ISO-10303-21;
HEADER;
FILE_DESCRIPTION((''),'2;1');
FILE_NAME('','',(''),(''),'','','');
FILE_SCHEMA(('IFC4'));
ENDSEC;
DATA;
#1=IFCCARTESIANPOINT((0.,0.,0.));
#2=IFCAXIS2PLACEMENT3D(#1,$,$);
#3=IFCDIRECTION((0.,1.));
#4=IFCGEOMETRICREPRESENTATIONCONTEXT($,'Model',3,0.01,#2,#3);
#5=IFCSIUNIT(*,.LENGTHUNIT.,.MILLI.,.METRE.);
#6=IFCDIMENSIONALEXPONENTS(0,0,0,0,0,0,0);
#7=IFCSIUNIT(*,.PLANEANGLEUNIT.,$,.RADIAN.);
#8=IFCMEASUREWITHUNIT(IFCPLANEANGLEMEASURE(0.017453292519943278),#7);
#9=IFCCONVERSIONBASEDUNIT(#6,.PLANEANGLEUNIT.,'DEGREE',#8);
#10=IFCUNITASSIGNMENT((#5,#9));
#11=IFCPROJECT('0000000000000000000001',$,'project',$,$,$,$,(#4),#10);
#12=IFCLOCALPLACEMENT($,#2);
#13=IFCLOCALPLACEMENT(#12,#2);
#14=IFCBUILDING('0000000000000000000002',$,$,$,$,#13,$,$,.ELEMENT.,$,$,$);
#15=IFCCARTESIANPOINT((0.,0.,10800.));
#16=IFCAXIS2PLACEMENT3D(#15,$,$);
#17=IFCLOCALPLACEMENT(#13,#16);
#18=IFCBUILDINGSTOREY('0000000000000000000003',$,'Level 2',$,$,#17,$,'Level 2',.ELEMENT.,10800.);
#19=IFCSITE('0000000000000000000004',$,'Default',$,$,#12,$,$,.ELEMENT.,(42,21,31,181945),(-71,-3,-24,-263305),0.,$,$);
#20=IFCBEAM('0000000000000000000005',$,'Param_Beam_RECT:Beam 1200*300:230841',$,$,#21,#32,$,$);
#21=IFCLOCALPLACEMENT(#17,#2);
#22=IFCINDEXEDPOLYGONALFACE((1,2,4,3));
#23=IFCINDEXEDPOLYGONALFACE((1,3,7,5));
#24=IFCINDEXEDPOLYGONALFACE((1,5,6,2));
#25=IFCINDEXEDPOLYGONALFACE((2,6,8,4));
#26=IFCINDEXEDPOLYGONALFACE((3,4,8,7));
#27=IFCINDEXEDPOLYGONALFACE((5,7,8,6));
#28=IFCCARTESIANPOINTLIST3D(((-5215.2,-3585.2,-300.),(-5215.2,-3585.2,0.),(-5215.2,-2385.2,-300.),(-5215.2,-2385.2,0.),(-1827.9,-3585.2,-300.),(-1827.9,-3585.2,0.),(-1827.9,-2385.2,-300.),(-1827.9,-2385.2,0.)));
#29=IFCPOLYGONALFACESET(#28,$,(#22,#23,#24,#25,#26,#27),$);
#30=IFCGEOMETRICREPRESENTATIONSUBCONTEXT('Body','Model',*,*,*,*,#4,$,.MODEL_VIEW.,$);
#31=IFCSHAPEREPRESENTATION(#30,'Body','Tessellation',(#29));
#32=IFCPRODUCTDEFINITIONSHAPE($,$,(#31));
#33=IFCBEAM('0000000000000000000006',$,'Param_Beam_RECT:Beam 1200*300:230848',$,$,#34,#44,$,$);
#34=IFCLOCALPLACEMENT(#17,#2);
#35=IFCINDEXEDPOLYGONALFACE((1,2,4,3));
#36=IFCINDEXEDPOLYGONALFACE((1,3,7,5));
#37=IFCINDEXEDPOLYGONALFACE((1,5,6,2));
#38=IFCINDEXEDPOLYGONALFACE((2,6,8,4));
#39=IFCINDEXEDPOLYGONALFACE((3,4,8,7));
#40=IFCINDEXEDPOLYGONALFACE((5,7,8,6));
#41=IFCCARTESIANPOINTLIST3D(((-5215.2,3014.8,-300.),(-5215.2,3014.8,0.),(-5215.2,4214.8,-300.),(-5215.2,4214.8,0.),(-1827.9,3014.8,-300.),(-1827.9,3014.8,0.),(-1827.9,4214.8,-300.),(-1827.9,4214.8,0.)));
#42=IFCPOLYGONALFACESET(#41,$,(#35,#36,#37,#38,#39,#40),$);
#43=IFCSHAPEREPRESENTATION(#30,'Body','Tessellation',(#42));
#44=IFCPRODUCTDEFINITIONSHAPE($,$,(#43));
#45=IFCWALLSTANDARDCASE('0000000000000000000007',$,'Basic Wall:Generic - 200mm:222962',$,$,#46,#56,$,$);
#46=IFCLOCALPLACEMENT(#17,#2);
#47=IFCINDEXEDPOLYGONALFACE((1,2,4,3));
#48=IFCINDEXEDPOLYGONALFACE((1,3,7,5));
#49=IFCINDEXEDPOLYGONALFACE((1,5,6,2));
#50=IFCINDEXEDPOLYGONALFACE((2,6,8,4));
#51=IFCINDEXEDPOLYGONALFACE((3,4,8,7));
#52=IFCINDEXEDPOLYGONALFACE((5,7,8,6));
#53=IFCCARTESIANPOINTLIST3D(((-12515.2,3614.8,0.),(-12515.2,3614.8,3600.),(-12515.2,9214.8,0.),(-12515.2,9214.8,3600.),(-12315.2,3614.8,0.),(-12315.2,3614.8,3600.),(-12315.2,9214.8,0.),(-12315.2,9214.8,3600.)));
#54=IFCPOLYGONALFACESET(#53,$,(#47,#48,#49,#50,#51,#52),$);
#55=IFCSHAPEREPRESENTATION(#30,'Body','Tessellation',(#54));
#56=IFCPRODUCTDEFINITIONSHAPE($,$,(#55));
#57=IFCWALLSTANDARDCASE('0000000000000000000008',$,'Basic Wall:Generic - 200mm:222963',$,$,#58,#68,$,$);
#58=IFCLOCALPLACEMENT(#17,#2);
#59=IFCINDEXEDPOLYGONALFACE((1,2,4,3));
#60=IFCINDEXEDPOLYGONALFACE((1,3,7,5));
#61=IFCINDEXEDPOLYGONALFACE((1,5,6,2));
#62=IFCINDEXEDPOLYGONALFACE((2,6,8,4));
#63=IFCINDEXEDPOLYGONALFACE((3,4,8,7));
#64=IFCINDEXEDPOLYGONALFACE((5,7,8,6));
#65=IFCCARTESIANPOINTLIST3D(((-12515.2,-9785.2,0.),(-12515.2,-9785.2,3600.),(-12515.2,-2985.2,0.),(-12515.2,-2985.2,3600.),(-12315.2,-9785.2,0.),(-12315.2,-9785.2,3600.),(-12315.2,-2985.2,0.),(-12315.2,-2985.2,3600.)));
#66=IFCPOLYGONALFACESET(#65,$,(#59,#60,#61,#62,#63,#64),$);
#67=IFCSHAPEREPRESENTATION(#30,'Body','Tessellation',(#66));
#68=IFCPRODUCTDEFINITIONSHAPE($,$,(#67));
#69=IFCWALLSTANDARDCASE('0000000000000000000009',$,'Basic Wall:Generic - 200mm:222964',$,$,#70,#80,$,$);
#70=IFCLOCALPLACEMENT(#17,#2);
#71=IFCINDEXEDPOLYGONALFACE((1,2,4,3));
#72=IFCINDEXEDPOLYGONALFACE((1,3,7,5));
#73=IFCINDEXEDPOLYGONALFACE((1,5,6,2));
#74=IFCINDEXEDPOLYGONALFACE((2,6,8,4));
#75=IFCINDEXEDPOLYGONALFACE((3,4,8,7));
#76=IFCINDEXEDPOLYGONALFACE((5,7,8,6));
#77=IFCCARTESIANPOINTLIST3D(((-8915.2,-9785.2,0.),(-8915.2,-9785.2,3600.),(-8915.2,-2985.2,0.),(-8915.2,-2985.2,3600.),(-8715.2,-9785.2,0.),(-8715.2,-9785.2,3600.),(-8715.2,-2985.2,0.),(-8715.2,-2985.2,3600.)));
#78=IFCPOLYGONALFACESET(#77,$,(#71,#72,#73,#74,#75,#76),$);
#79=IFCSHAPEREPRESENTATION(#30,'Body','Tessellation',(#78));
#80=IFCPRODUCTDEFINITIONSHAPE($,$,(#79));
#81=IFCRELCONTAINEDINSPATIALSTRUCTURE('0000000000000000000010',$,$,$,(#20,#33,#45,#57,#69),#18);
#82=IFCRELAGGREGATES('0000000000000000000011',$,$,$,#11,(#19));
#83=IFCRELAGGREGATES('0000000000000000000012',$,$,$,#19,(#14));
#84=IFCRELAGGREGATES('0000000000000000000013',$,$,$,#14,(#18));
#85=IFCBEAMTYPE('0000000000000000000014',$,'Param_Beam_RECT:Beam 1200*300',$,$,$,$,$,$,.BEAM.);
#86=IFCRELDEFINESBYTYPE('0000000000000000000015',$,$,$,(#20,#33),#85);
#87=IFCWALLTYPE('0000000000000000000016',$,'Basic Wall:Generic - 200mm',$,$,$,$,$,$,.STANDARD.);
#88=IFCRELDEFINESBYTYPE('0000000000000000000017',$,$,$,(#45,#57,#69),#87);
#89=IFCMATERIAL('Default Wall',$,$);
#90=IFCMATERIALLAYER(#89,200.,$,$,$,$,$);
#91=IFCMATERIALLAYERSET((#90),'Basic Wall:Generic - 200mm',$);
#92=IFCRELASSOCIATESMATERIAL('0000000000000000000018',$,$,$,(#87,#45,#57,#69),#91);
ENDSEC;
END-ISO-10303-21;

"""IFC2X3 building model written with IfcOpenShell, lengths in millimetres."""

from ifc_helpers import new_model, entity, si_unit, converted_unit, direction, frame, frame_2d, origin, place, context, subcontext, project, spatial, rectangle, extrude, material, layer, layer_set, layer_usage, type_object, element, save


model = new_model("IFC2X3")

# Units and contexts
model_context = context("Model", 3, precision=0.01, world=origin(), true_north=direction((0.0, 1.0)))
body_context = subcontext(model_context, "Body", "Model", "MODEL_VIEW")
ifc_project = project(units=[si_unit("LENGTHUNIT", "METRE", prefix="MILLI"), converted_unit("PLANEANGLEUNIT", "DEGREE", entity("IfcPlaneAngleMeasure", 0.017453292519943278), si_unit("PLANEANGLEUNIT", "RADIAN"), dimensions=[0, 0, 0, 0, 0, 0, 0])], contexts=[model_context])

# Site, building, storey
site_placement = place(None, origin())
site = spatial("IfcSite", under=ifc_project, at=site_placement, Name="Default", CompositionType="ELEMENT", RefLatitude=(42, 21, 31, 181945), RefLongitude=(-71, -3, -24, -263305), RefElevation=0.0)
building_placement = place(site_placement, origin())
building = spatial("IfcBuilding", under=site, at=building_placement, CompositionType="ELEMENT")
storey_placement = place(building_placement, frame((0.0, 0.0, 10800.0)))
storey = spatial("IfcBuildingStorey", under=building, at=storey_placement, Name="Level 2", LongName="Level 2", CompositionType="ELEMENT", Elevation=10800.0)

# Beams
beam_type_1 = type_object("IfcBeamType", Name="Param_Beam_RECT:Beam 1200*300", PredefinedType="BEAM")
beam_1_placement = place(storey_placement, frame((-5215.2, -2985.2, 0.0)))
element("IfcBeam", 1, at=beam_1_placement, inside=storey, type_object=beam_type_1, Name="Param_Beam_RECT:Beam 1200*300:230841", context=body_context, shape_type="SweptSolid", body=[
    extrude(rectangle(XDim=300.0, YDim=1200.0, at=frame_2d((0.0, 0.0), x_axis=(1.0, 0.0))), frame((0.0, 0.0, -150.0), z_axis=(1.0, 0.0, 0.0), x_axis=(0.0, 0.0, -1.0)), (0.0, 0.0, 1.0), 3387.3),
])
beam_2_placement = place(storey_placement, frame((-5215.2, 3614.8, 0.0)))
element("IfcBeam", 2, at=beam_2_placement, inside=storey, type_object=beam_type_1, Name="Param_Beam_RECT:Beam 1200*300:230848", context=body_context, shape_type="SweptSolid", body=[
    extrude(rectangle(XDim=300.0, YDim=1200.0, at=frame_2d((0.0, 0.0), x_axis=(1.0, 0.0))), frame((0.0, 0.0, -150.0), z_axis=(1.0, 0.0, 0.0), x_axis=(0.0, 0.0, -1.0)), (0.0, 0.0, 1.0), 3387.3),
])

# Walls
ifc_material_1 = material(Name="Default Wall")
ifc_layer = layer(ifc_material_1, 200.0)
ifc_layer_set = layer_set([ifc_layer], Name="Basic Wall:Generic - 200mm")
ifc_layer_usage_1 = layer_usage(ifc_layer_set, "AXIS2", "NEGATIVE", 100.0)
wall_type = type_object("IfcWallType", Name="Basic Wall:Generic - 200mm", PredefinedType="STANDARD", material=ifc_layer_set)
wall_1_placement = place(storey_placement, frame((-12415.2, 3614.8, 0.0), z_axis=(0.0, 0.0, 1.0), x_axis=(0.0, 1.0, 0.0)))
element("IfcWallStandardCase", 3, at=wall_1_placement, inside=storey, type_object=wall_type, material=ifc_layer_usage_1, Name="Basic Wall:Generic - 200mm:222962", context=body_context, shape_type="SweptSolid", body=[
    extrude(rectangle(XDim=5600.0, YDim=200.0, at=frame_2d((2800.0, 0.0), x_axis=(-1.0, 0.0))), origin(), (0.0, 0.0, 1.0), 3600.0),
])
ifc_layer_usage_2 = layer_usage(ifc_layer_set, "AXIS2", "NEGATIVE", 100.0)
wall_2_placement = place(storey_placement, frame((-12415.2, -9785.2, 0.0), z_axis=(0.0, 0.0, 1.0), x_axis=(0.0, 1.0, 0.0)))
element("IfcWallStandardCase", 4, at=wall_2_placement, inside=storey, type_object=wall_type, material=ifc_layer_usage_2, Name="Basic Wall:Generic - 200mm:222963", context=body_context, shape_type="SweptSolid", body=[
    extrude(rectangle(XDim=6800.0, YDim=200.0, at=frame_2d((3400.0, 0.0), x_axis=(-1.0, 0.0))), origin(), (0.0, 0.0, 1.0), 3600.0),
])
ifc_layer_usage_3 = layer_usage(ifc_layer_set, "AXIS2", "NEGATIVE", 100.0)
wall_3_placement = place(storey_placement, frame((-8815.2, -9785.2, 0.0), z_axis=(0.0, 0.0, 1.0), x_axis=(0.0, 1.0, 0.0)))
element("IfcWallStandardCase", 5, at=wall_3_placement, inside=storey, type_object=wall_type, material=ifc_layer_usage_3, Name="Basic Wall:Generic - 200mm:222964", context=body_context, shape_type="SweptSolid", body=[
    extrude(rectangle(XDim=6800.0, YDim=200.0, at=frame_2d((3400.0, 0.0), x_axis=(-1.0, 0.0))), origin(), (0.0, 0.0, 1.0), 3600.0),
])

save(model, "model.ifc")
